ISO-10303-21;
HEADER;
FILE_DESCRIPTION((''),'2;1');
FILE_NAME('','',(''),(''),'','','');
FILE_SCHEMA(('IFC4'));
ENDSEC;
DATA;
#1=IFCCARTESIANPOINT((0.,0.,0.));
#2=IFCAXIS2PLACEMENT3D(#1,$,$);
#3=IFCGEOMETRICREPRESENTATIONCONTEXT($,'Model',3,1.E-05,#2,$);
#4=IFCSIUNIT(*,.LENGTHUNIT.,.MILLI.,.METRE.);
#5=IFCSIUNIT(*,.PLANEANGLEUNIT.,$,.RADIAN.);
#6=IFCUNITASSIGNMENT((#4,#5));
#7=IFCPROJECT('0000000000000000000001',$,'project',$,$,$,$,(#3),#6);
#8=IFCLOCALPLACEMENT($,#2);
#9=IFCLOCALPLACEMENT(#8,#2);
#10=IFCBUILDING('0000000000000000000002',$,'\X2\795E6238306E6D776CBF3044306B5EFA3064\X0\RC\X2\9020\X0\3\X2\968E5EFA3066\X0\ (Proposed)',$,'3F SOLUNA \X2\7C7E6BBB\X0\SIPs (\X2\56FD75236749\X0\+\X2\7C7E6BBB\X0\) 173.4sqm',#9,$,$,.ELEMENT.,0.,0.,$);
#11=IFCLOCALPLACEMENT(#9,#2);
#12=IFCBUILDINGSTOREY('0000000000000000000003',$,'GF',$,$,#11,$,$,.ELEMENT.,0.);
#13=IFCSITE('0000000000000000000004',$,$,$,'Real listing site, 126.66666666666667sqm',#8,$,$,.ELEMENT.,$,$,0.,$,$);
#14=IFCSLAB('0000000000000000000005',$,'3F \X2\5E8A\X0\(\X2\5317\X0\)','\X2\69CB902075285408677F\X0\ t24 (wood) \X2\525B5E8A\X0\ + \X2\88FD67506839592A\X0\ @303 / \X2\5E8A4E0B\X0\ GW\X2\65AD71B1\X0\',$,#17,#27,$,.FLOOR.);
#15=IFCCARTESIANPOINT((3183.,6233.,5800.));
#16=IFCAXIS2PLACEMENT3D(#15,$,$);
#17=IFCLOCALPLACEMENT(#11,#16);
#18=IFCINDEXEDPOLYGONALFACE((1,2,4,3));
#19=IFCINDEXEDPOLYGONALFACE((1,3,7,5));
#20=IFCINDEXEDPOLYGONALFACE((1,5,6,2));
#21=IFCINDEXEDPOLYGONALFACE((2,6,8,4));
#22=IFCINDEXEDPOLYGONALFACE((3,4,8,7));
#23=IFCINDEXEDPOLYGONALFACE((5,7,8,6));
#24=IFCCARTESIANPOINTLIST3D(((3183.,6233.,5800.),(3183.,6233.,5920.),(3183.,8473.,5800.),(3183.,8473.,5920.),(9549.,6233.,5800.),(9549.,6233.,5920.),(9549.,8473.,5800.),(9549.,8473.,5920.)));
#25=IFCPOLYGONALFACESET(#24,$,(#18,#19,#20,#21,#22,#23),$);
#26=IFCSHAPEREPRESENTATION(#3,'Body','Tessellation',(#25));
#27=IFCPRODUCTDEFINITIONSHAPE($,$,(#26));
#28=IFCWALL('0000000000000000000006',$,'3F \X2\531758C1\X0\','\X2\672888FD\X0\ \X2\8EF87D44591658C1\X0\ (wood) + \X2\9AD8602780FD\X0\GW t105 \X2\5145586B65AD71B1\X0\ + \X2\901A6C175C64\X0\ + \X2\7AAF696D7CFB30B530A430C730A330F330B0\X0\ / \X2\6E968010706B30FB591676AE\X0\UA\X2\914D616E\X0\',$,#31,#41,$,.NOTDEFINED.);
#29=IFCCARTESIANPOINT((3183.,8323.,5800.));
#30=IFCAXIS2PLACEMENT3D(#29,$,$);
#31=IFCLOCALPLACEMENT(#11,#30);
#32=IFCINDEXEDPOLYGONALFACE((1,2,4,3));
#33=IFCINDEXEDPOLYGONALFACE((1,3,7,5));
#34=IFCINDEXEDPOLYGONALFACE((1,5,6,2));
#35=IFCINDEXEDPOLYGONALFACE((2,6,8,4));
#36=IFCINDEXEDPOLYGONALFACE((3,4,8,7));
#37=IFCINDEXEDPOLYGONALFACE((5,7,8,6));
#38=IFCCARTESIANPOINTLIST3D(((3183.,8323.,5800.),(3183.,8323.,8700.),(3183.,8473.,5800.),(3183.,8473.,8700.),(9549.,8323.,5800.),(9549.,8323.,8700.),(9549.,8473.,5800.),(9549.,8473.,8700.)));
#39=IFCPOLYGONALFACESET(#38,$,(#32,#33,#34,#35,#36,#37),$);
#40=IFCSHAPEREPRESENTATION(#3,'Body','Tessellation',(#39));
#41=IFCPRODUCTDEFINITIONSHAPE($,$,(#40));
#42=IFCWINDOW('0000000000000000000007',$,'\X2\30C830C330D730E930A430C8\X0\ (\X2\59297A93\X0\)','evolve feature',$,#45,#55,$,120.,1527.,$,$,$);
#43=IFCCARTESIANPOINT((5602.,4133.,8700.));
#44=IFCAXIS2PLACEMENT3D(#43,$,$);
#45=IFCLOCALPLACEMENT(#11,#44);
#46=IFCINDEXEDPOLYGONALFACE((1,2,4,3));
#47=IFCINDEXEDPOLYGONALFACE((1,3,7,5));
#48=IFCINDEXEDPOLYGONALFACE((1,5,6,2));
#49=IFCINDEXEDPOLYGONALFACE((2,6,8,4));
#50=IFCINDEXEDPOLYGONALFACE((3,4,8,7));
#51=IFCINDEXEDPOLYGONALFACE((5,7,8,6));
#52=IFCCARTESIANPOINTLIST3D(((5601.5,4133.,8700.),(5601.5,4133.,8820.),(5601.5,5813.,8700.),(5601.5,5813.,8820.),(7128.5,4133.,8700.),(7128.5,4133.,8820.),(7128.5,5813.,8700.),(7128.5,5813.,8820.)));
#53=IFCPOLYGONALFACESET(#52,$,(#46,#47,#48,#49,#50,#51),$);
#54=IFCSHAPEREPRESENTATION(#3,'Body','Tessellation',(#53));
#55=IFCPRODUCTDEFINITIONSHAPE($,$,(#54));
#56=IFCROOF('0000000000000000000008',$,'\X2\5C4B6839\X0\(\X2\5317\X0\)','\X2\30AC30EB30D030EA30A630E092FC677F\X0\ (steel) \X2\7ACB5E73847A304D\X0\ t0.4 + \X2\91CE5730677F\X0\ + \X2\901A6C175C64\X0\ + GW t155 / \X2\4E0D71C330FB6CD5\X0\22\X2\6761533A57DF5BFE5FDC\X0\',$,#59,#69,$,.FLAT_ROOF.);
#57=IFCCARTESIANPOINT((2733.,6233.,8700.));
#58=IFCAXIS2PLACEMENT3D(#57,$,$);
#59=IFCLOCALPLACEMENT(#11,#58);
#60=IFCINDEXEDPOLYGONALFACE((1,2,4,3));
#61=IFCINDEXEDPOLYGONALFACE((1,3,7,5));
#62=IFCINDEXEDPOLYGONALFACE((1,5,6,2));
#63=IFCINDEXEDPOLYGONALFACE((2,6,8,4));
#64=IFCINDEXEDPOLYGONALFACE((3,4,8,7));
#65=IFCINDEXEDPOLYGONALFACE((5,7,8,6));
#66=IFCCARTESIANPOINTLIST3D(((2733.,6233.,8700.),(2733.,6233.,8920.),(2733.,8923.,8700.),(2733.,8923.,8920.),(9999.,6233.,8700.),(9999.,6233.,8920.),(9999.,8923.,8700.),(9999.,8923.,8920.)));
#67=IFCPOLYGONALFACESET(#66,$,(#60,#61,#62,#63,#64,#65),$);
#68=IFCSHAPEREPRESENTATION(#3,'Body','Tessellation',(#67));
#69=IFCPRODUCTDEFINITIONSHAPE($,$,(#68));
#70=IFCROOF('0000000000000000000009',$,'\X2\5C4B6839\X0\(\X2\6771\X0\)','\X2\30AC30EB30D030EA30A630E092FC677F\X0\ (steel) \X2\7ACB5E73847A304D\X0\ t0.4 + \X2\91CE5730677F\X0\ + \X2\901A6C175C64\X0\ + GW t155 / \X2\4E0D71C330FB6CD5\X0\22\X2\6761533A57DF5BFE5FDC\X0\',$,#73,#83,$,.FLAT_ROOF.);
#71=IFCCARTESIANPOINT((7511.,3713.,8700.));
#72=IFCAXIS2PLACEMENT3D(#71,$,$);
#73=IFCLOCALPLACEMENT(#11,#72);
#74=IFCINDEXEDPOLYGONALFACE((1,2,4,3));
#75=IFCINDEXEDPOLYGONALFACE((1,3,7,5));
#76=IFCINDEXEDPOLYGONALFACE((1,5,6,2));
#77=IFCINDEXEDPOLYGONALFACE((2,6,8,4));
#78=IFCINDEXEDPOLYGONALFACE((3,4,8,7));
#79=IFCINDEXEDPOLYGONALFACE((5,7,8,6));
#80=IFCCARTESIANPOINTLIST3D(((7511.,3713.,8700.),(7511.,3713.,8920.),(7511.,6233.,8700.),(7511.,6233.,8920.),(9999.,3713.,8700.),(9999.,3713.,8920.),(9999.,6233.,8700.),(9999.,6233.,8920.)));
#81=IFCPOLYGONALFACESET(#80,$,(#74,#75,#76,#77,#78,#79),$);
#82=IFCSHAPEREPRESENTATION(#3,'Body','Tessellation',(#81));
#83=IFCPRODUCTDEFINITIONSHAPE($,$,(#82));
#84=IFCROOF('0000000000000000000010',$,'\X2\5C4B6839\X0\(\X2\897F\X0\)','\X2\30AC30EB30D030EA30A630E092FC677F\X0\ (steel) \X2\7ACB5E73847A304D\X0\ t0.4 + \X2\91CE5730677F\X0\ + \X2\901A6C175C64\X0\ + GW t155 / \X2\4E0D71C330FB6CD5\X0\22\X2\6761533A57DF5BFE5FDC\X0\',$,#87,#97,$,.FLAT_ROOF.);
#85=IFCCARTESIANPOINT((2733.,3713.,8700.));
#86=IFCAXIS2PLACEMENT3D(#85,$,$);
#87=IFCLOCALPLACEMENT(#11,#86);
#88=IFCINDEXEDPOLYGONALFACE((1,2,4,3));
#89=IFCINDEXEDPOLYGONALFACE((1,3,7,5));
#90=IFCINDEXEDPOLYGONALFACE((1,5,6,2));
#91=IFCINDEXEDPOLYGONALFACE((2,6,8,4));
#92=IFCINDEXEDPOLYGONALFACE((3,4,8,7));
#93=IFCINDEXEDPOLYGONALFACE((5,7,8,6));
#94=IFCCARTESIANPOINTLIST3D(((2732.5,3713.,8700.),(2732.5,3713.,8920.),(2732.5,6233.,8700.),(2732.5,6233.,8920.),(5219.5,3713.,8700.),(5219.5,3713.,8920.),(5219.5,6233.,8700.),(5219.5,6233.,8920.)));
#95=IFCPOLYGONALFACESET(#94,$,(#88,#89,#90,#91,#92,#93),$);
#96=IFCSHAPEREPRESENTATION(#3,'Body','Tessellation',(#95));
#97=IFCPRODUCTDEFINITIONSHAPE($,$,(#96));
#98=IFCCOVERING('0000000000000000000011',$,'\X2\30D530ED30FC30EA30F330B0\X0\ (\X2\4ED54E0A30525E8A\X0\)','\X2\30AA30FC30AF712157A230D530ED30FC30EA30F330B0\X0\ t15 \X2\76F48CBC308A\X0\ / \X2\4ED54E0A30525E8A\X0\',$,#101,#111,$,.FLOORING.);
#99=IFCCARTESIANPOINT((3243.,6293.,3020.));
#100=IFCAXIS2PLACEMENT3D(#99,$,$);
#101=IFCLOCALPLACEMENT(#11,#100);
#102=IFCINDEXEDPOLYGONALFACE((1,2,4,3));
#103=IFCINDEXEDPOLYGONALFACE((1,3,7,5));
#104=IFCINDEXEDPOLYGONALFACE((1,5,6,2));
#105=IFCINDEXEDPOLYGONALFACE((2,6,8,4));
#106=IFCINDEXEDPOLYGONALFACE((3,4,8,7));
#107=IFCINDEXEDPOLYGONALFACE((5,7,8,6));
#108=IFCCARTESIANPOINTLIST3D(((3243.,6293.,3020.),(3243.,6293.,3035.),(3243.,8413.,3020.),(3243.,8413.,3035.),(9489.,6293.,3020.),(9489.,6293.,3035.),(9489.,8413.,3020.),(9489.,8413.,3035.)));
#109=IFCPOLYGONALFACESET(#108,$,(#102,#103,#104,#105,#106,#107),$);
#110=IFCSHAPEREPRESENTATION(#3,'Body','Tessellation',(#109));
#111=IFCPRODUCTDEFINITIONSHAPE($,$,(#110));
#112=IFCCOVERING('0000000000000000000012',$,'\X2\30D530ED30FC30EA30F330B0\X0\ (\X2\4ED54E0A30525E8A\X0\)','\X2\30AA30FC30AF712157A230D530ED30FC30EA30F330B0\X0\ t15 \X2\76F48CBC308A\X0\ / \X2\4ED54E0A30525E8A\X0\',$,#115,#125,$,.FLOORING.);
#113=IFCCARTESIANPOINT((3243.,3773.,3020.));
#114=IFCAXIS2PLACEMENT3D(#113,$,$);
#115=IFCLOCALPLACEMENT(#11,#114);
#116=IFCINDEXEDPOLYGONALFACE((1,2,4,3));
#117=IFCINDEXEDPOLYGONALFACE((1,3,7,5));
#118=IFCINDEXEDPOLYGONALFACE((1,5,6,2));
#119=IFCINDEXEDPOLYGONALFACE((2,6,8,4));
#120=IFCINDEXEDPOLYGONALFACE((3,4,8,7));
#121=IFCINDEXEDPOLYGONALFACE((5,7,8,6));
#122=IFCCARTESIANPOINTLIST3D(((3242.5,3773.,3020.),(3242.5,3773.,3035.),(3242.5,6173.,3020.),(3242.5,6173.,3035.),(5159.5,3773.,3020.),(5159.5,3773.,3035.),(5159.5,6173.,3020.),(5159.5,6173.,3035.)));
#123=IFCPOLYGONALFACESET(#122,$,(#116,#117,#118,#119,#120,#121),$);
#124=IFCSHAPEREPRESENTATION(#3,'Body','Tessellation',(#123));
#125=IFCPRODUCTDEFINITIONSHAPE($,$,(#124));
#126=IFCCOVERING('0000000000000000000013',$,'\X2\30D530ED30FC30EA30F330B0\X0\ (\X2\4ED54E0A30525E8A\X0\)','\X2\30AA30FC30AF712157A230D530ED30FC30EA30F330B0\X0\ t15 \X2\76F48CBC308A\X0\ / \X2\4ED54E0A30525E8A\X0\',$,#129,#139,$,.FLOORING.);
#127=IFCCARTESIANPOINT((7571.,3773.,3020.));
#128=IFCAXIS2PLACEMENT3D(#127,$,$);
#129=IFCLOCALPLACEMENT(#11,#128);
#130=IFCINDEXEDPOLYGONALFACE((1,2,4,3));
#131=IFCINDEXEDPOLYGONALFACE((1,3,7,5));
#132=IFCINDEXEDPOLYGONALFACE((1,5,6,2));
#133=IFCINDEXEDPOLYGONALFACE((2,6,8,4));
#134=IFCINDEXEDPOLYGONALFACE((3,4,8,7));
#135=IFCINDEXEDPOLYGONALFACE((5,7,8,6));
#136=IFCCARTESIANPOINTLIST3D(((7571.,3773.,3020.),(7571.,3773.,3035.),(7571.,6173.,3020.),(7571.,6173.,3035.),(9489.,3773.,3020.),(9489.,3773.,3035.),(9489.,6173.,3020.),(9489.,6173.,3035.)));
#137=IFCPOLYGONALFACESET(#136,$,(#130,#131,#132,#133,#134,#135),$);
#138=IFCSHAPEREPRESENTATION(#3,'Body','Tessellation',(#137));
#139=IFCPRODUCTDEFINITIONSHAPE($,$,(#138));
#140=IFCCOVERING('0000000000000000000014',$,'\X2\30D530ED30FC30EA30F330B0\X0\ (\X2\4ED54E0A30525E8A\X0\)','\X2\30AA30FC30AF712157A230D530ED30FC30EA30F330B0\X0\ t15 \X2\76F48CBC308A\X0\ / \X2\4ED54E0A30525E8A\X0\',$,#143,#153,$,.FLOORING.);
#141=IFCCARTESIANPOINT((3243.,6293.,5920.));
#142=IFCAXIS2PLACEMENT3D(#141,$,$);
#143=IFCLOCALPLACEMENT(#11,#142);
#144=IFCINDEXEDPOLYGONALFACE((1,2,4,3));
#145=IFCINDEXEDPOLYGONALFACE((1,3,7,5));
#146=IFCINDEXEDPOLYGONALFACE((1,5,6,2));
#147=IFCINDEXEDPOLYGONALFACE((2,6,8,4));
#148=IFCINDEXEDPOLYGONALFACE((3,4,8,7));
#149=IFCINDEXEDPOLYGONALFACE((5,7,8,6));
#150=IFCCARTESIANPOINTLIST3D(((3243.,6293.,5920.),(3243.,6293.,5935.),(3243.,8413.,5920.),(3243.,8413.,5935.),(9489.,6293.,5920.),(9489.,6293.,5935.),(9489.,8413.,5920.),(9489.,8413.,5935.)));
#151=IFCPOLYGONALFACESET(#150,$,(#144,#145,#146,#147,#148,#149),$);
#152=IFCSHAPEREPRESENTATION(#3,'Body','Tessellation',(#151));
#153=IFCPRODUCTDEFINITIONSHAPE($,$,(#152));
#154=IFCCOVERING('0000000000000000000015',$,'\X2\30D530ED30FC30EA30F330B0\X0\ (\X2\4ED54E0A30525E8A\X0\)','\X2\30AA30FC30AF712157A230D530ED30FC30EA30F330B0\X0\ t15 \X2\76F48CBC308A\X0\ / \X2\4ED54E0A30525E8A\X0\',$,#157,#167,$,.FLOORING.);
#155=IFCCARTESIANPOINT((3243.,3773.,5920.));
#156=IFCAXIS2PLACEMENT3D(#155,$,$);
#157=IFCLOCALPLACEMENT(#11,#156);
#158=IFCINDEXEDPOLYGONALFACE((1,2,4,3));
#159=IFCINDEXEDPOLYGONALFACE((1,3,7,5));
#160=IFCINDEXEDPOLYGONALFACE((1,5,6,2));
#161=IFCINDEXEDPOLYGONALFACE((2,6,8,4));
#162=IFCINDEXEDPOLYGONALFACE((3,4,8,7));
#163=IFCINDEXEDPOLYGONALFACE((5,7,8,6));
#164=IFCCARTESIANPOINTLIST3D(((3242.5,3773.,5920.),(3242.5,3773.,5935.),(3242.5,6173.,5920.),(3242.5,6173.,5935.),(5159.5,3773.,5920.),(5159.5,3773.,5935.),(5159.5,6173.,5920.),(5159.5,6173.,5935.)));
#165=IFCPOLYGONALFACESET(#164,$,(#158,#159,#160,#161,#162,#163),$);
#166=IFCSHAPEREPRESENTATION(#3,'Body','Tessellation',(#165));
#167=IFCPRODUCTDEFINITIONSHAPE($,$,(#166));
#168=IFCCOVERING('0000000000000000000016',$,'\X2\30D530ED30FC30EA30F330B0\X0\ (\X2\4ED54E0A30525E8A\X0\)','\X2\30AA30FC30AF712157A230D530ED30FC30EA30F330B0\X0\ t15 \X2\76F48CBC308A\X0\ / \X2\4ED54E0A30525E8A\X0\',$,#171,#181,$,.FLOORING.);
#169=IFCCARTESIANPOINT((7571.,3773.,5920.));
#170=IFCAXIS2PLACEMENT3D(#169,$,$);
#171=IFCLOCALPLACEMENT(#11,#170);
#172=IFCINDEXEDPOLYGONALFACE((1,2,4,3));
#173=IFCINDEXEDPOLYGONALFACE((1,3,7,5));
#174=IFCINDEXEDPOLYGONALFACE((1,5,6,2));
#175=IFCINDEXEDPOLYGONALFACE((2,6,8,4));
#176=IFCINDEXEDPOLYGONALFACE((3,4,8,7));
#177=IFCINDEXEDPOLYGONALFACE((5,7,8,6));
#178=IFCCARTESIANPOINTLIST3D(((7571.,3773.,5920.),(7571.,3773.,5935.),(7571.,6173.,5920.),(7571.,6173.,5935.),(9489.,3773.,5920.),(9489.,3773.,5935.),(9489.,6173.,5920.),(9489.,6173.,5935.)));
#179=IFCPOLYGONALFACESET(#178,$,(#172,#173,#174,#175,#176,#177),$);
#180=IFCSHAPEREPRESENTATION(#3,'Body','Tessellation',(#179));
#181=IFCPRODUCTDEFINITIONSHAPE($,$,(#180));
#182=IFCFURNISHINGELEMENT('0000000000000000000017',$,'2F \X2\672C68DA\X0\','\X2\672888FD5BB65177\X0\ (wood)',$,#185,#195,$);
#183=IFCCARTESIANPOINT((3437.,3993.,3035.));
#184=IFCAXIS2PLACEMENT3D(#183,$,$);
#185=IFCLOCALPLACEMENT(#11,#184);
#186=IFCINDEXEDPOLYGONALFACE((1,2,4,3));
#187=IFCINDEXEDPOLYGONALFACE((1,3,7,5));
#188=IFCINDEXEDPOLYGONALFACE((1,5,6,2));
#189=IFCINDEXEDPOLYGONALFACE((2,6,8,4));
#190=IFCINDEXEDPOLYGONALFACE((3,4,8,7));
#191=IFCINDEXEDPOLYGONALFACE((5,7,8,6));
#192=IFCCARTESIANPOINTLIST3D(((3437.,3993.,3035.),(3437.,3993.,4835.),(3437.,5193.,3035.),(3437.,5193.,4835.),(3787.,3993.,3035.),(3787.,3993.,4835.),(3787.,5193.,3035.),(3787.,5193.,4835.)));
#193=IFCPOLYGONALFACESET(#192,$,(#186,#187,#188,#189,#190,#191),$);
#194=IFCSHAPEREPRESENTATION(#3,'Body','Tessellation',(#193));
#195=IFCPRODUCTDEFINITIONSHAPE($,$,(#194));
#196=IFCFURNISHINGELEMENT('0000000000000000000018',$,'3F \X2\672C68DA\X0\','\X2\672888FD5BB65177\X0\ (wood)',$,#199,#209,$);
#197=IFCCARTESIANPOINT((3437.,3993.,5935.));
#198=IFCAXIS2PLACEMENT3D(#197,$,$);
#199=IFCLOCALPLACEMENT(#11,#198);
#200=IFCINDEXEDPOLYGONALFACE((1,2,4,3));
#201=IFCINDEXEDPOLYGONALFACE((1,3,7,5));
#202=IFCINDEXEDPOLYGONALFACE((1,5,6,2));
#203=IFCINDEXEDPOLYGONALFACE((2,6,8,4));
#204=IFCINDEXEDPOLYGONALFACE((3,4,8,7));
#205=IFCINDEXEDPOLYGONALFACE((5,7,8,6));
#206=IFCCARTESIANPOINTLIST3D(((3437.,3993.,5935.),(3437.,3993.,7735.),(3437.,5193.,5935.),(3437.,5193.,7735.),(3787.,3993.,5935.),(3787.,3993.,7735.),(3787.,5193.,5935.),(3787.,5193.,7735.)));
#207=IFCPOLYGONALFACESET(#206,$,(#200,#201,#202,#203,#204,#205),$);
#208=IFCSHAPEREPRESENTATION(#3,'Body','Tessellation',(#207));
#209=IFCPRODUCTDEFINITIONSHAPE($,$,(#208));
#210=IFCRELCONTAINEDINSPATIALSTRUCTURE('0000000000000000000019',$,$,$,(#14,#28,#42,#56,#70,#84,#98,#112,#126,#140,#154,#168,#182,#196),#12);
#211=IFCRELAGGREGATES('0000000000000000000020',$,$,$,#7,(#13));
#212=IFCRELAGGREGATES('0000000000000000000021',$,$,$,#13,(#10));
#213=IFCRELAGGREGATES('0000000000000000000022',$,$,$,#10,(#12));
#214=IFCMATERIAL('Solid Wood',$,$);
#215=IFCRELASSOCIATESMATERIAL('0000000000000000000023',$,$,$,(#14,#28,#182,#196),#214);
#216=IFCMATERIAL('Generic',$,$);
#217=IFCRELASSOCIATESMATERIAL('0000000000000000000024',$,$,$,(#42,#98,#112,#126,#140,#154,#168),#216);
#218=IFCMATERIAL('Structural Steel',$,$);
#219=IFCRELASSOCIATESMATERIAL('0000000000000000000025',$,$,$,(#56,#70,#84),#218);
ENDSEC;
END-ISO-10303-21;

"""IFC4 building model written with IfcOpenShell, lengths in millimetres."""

from ifc_helpers import new_model, si_unit, frame, frame_2d, origin, place, context, project, spatial, rectangle, extrude, material, element, save


model = new_model("IFC4")

# Units and contexts
model_context = context("Model", 3, precision=1e-05, world=origin())
ifc_project = project(units=[si_unit("LENGTHUNIT", "METRE", prefix="MILLI"), si_unit("PLANEANGLEUNIT", "RADIAN")], contexts=[model_context])

# Site, building, storey
site_placement = place(None, origin())
site = spatial("IfcSite", under=ifc_project, at=site_placement, ObjectType="Real listing site, 126.66666666666667sqm", CompositionType="ELEMENT", RefElevation=0.0)
building_placement = place(site_placement, origin())
building = spatial("IfcBuilding", under=site, at=building_placement, Name="神戸の海沿いに建つRC造3階建て (Proposed)", ObjectType="3F SOLUNA 籾殻SIPs (国産杉+籾殻) 173.4sqm", CompositionType="ELEMENT", ElevationOfRefHeight=0.0, ElevationOfTerrain=0.0)
storey_placement = place(building_placement, origin())
storey = spatial("IfcBuildingStorey", under=building, at=storey_placement, Name="GF", CompositionType="ELEMENT", Elevation=0.0)

# Slab
ifc_material_1 = material(Name="Solid Wood")
slab_placement = place(storey_placement, frame((3183.0, 6233.0, 5800.0)))
element("IfcSlab", 1, at=slab_placement, inside=storey, material=ifc_material_1, Name="3F 床(北)", Description="構造用合板 t24 (wood) 剛床 + 製材根太 @303 / 床下 GW断熱", PredefinedType="FLOOR", context=model_context, shape_type="SweptSolid", body=[
    extrude(rectangle(XDim=6366.0, YDim=2240.0, at=frame_2d((3183.0, 1120.0))), frame((3183.0, 6233.0, 5800.0)), (0.0, 0.0, 1.0), 120.0),
])

# Wall
wall_1_placement = place(storey_placement, frame((3183.0, 8323.0, 5800.0)))
element("IfcWall", 2, at=wall_1_placement, inside=storey, material=ifc_material_1, Name="3F 北壁", Description="木製 軸組外壁 (wood) + 高性能GW t105 充填断熱 + 通気層 + 窯業系サイディング / 準耐火・外皮UA配慮", PredefinedType="NOTDEFINED", context=model_context, shape_type="SweptSolid", body=[
    extrude(rectangle(XDim=6366.0, YDim=150.0, at=frame_2d((3183.0, 75.0))), frame((3183.0, 8323.0, 5800.0)), (0.0, 0.0, 1.0), 2900.0),
])

# Window
ifc_material_2 = material(Name="Generic")
window_1_placement = place(storey_placement, frame((5602.0, 4133.0, 8700.0)))
element("IfcWindow", 3, at=window_1_placement, inside=storey, material=ifc_material_2, Name="トップライト (天窓)", Description="evolve feature", OverallHeight=120.0, OverallWidth=1527.0, context=model_context, shape_type="SweptSolid", body=[
    extrude(rectangle(XDim=1527.0, YDim=1680.0, at=frame_2d((763.0, 840.0))), frame((5602.0, 4133.0, 8700.0)), (0.0, 0.0, 1.0), 120.0),
])

# Roofs
ifc_material_3 = material(Name="Structural Steel")
roof_1_placement = place(storey_placement, frame((2733.0, 6233.0, 8700.0)))
element("IfcRoof", 4, at=roof_1_placement, inside=storey, material=ifc_material_3, Name="屋根(北)", Description="ガルバリウム鋼板 (steel) 立平葺き t0.4 + 野地板 + 通気層 + GW t155 / 不燃・法22条区域対応", PredefinedType="FLAT_ROOF", context=model_context, shape_type="SweptSolid", body=[
    extrude(rectangle(XDim=7266.0, YDim=2690.0, at=frame_2d((3633.0, 1345.0))), frame((2733.0, 6233.0, 8700.0)), (0.0, 0.0, 1.0), 220.0),
])
roof_2_placement = place(storey_placement, frame((7511.0, 3713.0, 8700.0)))
element("IfcRoof", 5, at=roof_2_placement, inside=storey, material=ifc_material_3, Name="屋根(東)", Description="ガルバリウム鋼板 (steel) 立平葺き t0.4 + 野地板 + 通気層 + GW t155 / 不燃・法22条区域対応", PredefinedType="FLAT_ROOF", context=model_context, shape_type="SweptSolid", body=[
    extrude(rectangle(XDim=2488.0, YDim=2520.0, at=frame_2d((1244.0, 1260.0))), frame((7511.0, 3713.0, 8700.0)), (0.0, 0.0, 1.0), 220.0),
])
roof_3_placement = place(storey_placement, frame((2733.0, 3713.0, 8700.0)))
element("IfcRoof", 6, at=roof_3_placement, inside=storey, material=ifc_material_3, Name="屋根(西)", Description="ガルバリウム鋼板 (steel) 立平葺き t0.4 + 野地板 + 通気層 + GW t155 / 不燃・法22条区域対応", PredefinedType="FLAT_ROOF", context=model_context, shape_type="SweptSolid", body=[
    extrude(rectangle(XDim=2487.0, YDim=2520.0, at=frame_2d((1243.0, 1260.0))), frame((2733.0, 3713.0, 8700.0)), (0.0, 0.0, 1.0), 220.0),
])

# Coverings
covering_1_placement = place(storey_placement, frame((3243.0, 6293.0, 3020.0)))
element("IfcCovering", 7, at=covering_1_placement, inside=storey, material=ifc_material_2, Name="フローリング (仕上げ床)", Description="オーク無垢フローリング t15 直貼り / 仕上げ床", PredefinedType="FLOORING", context=model_context, shape_type="SweptSolid", body=[
    extrude(rectangle(XDim=6246.0, YDim=2120.0, at=frame_2d((3123.0, 1060.0))), frame((3243.0, 6293.0, 3020.0)), (0.0, 0.0, 1.0), 15.0),
])
covering_2_placement = place(storey_placement, frame((3243.0, 3773.0, 3020.0)))
element("IfcCovering", 8, at=covering_2_placement, inside=storey, material=ifc_material_2, Name="フローリング (仕上げ床)", Description="オーク無垢フローリング t15 直貼り / 仕上げ床", PredefinedType="FLOORING", context=model_context, shape_type="SweptSolid", body=[
    extrude(rectangle(XDim=1917.0, YDim=2400.0, at=frame_2d((958.0, 1200.0))), frame((3243.0, 3773.0, 3020.0)), (0.0, 0.0, 1.0), 15.0),
])
covering_3_placement = place(storey_placement, frame((7571.0, 3773.0, 3020.0)))
element("IfcCovering", 9, at=covering_3_placement, inside=storey, material=ifc_material_2, Name="フローリング (仕上げ床)", Description="オーク無垢フローリング t15 直貼り / 仕上げ床", PredefinedType="FLOORING", context=model_context, shape_type="SweptSolid", body=[
    extrude(rectangle(XDim=1918.0, YDim=2400.0, at=frame_2d((959.0, 1200.0))), frame((7571.0, 3773.0, 3020.0)), (0.0, 0.0, 1.0), 15.0),
])
covering_4_placement = place(storey_placement, frame((3243.0, 6293.0, 5920.0)))
element("IfcCovering", 10, at=covering_4_placement, inside=storey, material=ifc_material_2, Name="フローリング (仕上げ床)", Description="オーク無垢フローリング t15 直貼り / 仕上げ床", PredefinedType="FLOORING", context=model_context, shape_type="SweptSolid", body=[
    extrude(rectangle(XDim=6246.0, YDim=2120.0, at=frame_2d((3123.0, 1060.0))), frame((3243.0, 6293.0, 5920.0)), (0.0, 0.0, 1.0), 15.0),
])
covering_5_placement = place(storey_placement, frame((3243.0, 3773.0, 5920.0)))
element("IfcCovering", 11, at=covering_5_placement, inside=storey, material=ifc_material_2, Name="フローリング (仕上げ床)", Description="オーク無垢フローリング t15 直貼り / 仕上げ床", PredefinedType="FLOORING", context=model_context, shape_type="SweptSolid", body=[
    extrude(rectangle(XDim=1917.0, YDim=2400.0, at=frame_2d((958.0, 1200.0))), frame((3243.0, 3773.0, 5920.0)), (0.0, 0.0, 1.0), 15.0),
])
covering_6_placement = place(storey_placement, frame((7571.0, 3773.0, 5920.0)))
element("IfcCovering", 12, at=covering_6_placement, inside=storey, material=ifc_material_2, Name="フローリング (仕上げ床)", Description="オーク無垢フローリング t15 直貼り / 仕上げ床", PredefinedType="FLOORING", context=model_context, shape_type="SweptSolid", body=[
    extrude(rectangle(XDim=1918.0, YDim=2400.0, at=frame_2d((959.0, 1200.0))), frame((7571.0, 3773.0, 5920.0)), (0.0, 0.0, 1.0), 15.0),
])

# Furnishing elements
furnishing_1_placement = place(storey_placement, frame((3437.0, 3993.0, 3035.0)))
element("IfcFurnishingElement", 13, at=furnishing_1_placement, inside=storey, material=ifc_material_1, Name="2F 本棚", Description="木製家具 (wood)", context=model_context, shape_type="SweptSolid", body=[
    extrude(rectangle(XDim=350.0, YDim=1200.0, at=frame_2d((175.0, 600.0))), frame((3437.0, 3993.0, 3035.0)), (0.0, 0.0, 1.0), 1800.0),
])
furnishing_2_placement = place(storey_placement, frame((3437.0, 3993.0, 5935.0)))
element("IfcFurnishingElement", 14, at=furnishing_2_placement, inside=storey, material=ifc_material_1, Name="3F 本棚", Description="木製家具 (wood)", context=model_context, shape_type="SweptSolid", body=[
    extrude(rectangle(XDim=350.0, YDim=1200.0, at=frame_2d((175.0, 600.0))), frame((3437.0, 3993.0, 5935.0)), (0.0, 0.0, 1.0), 1800.0),
])

save(model, "model.ifc")
